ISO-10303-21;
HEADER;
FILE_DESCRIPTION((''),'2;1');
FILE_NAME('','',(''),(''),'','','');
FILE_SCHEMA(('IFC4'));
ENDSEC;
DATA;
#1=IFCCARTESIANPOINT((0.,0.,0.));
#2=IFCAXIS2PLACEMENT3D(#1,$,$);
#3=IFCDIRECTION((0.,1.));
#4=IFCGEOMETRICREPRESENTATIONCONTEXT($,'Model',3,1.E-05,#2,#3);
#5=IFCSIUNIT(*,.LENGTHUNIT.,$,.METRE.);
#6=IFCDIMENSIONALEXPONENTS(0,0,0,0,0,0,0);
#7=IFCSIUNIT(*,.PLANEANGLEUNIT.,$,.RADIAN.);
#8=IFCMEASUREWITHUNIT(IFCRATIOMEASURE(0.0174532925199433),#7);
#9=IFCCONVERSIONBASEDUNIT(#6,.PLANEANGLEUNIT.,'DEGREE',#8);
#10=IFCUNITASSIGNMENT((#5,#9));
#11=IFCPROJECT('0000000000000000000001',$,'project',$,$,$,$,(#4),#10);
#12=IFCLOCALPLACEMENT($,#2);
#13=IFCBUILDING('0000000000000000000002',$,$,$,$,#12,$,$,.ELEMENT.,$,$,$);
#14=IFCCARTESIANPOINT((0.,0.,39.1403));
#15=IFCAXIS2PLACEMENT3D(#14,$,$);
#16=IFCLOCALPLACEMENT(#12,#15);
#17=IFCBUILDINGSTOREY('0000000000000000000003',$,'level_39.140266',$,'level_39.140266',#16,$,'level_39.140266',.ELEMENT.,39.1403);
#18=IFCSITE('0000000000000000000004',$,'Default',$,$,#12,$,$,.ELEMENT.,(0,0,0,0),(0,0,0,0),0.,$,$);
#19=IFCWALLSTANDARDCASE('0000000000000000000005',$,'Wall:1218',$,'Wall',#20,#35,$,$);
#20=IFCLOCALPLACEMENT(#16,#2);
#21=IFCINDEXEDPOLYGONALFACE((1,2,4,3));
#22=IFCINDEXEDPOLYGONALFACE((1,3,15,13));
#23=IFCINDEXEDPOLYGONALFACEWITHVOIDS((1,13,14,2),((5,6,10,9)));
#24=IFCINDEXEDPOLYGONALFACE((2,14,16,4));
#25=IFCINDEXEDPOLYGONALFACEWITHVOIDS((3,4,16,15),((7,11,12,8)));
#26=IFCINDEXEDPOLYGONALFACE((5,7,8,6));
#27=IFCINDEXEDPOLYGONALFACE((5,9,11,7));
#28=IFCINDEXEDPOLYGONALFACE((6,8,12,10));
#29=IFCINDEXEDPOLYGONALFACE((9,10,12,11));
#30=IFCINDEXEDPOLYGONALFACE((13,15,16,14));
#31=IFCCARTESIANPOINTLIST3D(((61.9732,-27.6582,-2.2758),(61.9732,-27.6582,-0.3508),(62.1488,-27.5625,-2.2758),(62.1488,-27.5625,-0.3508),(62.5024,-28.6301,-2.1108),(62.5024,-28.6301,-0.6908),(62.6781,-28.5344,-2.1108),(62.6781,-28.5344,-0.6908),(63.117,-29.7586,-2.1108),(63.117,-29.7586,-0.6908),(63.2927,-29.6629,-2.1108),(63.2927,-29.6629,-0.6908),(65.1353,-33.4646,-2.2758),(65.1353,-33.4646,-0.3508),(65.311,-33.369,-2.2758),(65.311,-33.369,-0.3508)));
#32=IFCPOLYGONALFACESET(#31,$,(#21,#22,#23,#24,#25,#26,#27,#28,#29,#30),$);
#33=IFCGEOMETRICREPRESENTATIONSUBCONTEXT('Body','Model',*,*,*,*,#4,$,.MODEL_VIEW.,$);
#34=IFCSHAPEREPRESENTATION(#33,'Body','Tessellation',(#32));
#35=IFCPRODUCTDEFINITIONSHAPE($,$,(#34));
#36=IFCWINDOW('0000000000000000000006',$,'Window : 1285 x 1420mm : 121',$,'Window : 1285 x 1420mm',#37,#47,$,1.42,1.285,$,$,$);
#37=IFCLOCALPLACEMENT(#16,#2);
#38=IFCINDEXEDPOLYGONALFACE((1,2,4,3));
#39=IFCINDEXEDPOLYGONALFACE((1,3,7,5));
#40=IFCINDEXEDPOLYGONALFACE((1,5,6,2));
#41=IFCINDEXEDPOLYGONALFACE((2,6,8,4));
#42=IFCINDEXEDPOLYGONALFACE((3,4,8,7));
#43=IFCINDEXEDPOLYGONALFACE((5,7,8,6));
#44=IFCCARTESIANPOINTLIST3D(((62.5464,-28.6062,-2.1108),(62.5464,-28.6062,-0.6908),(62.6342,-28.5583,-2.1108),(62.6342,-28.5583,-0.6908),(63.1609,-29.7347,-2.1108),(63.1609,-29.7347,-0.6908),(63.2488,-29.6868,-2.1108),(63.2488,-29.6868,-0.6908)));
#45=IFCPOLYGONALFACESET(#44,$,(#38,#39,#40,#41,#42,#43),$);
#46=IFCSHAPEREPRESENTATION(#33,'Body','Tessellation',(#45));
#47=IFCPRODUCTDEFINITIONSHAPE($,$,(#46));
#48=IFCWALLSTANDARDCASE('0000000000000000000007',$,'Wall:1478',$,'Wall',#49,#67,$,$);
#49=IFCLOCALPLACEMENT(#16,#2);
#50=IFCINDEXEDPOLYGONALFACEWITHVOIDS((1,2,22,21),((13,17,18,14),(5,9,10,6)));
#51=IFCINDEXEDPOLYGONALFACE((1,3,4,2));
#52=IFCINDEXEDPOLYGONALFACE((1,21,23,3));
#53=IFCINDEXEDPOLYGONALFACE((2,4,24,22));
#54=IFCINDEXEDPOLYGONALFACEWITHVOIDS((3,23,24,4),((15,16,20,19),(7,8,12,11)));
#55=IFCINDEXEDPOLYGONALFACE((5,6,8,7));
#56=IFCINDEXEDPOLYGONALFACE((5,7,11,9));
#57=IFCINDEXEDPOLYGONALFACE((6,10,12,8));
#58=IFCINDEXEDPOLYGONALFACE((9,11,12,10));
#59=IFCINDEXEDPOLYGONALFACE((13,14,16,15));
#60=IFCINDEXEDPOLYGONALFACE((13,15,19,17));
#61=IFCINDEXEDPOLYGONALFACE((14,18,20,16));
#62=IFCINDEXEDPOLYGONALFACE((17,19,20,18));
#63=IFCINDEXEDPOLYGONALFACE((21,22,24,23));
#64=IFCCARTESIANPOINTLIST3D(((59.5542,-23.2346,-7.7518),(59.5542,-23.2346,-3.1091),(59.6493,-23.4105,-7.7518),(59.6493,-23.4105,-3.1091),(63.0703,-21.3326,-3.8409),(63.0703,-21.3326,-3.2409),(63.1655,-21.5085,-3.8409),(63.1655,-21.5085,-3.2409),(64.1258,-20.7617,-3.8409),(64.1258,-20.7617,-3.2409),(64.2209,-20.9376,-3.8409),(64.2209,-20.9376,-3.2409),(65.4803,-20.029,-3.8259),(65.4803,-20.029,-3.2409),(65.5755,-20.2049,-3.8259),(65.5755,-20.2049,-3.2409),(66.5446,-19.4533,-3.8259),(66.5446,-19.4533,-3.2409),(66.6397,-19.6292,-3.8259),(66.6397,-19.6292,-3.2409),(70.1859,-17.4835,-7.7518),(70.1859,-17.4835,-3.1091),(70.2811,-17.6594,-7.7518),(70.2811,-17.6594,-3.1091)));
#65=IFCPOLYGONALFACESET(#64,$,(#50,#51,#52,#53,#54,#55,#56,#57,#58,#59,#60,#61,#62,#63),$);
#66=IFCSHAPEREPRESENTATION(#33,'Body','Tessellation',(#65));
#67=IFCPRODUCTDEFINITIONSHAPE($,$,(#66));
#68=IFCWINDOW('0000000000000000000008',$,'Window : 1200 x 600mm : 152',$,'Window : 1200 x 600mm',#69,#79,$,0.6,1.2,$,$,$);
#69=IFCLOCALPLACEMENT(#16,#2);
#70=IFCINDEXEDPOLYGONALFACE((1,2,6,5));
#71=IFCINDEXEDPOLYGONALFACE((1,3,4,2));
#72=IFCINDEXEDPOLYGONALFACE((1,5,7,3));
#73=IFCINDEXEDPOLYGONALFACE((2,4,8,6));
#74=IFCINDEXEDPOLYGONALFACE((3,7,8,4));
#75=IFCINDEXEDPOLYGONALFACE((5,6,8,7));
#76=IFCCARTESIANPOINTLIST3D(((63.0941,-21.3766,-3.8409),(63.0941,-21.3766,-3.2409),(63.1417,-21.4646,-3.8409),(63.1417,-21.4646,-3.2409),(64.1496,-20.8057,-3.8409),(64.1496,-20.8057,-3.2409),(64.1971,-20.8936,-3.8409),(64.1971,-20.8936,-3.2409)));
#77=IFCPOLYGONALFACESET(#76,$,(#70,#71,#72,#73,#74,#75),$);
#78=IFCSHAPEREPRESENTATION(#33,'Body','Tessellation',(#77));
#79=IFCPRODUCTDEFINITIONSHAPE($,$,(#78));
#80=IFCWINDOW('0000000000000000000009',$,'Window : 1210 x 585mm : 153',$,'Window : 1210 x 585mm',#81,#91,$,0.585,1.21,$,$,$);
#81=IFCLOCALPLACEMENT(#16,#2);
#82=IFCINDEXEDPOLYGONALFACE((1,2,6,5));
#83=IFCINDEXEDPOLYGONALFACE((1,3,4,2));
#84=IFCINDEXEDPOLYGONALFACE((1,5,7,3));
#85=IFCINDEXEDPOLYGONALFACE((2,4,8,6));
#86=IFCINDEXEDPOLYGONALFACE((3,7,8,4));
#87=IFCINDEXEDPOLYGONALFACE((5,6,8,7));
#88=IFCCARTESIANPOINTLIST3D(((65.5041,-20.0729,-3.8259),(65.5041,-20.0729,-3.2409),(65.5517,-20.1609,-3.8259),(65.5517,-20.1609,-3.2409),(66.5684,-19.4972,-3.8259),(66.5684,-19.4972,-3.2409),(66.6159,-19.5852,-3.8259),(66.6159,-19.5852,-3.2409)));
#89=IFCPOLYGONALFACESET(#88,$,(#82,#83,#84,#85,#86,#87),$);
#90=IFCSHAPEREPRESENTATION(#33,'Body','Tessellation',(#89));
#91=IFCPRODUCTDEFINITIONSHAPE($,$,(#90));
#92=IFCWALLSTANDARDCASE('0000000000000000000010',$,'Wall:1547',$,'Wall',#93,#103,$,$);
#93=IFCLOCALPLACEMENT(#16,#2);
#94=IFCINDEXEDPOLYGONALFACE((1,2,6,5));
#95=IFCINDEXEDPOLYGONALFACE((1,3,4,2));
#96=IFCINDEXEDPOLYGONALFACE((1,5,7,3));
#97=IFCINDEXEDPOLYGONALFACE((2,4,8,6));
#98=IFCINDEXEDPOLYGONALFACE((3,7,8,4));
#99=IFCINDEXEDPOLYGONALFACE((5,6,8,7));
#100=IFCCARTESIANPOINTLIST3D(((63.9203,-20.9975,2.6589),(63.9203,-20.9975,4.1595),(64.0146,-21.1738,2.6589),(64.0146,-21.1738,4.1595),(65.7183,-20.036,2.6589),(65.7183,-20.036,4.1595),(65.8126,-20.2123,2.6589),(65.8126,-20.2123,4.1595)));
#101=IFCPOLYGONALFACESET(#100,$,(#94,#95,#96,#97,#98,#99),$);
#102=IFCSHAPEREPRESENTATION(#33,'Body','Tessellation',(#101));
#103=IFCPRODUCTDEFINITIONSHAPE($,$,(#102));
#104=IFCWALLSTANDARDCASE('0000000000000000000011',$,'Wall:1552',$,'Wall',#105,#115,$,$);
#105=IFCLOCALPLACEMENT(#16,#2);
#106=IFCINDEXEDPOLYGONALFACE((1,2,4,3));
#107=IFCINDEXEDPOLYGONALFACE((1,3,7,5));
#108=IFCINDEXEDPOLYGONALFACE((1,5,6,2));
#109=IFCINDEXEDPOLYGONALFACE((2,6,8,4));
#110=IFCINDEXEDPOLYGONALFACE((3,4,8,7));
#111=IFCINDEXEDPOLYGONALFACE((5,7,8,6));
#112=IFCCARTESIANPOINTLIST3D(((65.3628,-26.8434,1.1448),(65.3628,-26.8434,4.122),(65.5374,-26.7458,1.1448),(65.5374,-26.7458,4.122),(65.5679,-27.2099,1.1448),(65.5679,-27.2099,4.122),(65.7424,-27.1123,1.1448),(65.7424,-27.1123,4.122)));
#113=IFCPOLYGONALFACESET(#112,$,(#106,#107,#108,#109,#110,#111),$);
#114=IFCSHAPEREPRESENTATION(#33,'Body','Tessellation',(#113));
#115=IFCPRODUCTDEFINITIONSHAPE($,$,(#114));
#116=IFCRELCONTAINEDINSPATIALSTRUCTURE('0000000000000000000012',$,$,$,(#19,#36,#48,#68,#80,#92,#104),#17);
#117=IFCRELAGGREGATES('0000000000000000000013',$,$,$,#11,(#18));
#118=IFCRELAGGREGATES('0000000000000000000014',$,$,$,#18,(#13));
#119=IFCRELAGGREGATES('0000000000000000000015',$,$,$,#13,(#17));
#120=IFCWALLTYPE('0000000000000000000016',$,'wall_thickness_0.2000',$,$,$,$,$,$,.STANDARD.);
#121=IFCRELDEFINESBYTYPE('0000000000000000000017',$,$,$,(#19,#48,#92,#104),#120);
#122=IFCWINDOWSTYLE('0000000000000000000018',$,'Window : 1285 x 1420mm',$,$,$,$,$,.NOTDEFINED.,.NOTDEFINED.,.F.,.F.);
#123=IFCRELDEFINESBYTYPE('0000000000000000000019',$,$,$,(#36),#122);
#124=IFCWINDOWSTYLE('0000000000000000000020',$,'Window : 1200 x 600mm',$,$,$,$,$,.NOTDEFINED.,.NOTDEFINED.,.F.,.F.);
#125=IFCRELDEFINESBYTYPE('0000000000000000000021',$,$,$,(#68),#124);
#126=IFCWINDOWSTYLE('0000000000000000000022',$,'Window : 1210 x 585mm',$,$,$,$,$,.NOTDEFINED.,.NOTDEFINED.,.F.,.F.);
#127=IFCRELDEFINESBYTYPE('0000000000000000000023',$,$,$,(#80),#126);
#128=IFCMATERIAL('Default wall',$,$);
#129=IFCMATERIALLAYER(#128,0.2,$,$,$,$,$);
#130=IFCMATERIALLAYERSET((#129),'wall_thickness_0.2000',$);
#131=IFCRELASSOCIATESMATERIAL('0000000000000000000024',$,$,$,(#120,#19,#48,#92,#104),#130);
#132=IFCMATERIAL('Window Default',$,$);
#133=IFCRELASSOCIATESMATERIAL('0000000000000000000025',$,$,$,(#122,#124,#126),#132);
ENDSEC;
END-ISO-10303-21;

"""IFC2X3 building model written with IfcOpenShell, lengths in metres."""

from ifc_helpers import new_model, entity, si_unit, converted_unit, direction, frame, frame_2d, origin, origin_2d_with_axis, place, context, subcontext, project, spatial, polyline, rectangle, outline, extrude, source, transform, mapped, material, layer, layer_set, layer_usage, type_object, type_shapes, element, fill, save


model = new_model("IFC2X3")

# Units and contexts
model_context = context("Model", 3, precision=1e-05, world=origin(), true_north=direction((0.0, 1.0)))
body_context = subcontext(model_context, "Body", "Model", "MODEL_VIEW")
ifc_project = project(units=[si_unit("LENGTHUNIT", "METRE"), converted_unit("PLANEANGLEUNIT", "DEGREE", entity("IfcRatioMeasure", 0.0174532925199433), si_unit("PLANEANGLEUNIT", "RADIAN"), dimensions=[0, 0, 0, 0, 0, 0, 0])], contexts=[model_context])

# Site, building, storey
placement_1 = place(None, origin())
site = spatial("IfcSite", under=ifc_project, at=placement_1, Name="Default", CompositionType="ELEMENT", RefLatitude=(0, 0, 0, 0), RefLongitude=(0, 0, 0, 0), RefElevation=0.0)
building = spatial("IfcBuilding", under=site, at=placement_1, CompositionType="ELEMENT")
storey_placement = place(placement_1, frame((0.0, 0.0, 39.1403)))
storey = spatial("IfcBuildingStorey", under=building, at=storey_placement, Name="level_39.140266", ObjectType="level_39.140266", LongName="level_39.140266", CompositionType="ELEMENT", Elevation=39.1403)

# Shared definitions
ifc_material_1 = material(Name="Default wall")
ifc_layer = layer(ifc_material_1, 0.2)
ifc_layer_set = layer_set([ifc_layer], Name="wall_thickness_0.2000")
ifc_layer_usage = layer_usage(ifc_layer_set, "AXIS2", "POSITIVE", -0.1)
wall_type = type_object("IfcWallType", Name="wall_thickness_0.2000", PredefinedType="STANDARD", material=ifc_layer_set)

# Shared definitions
ifc_material_2 = material(Name="Window Default")

# Wall, opening, window
placement_2 = place(placement_1, frame((0.0, 0.0, 36.8645)))
wall_1_placement = place(placement_2, frame((62.061, -27.6104, 0.0), z_axis=(0.0, 0.0, 1.0), x_axis=(0.478271, -0.878213, 0.0)))
wall_1 = element("IfcWallStandardCase", 1, at=wall_1_placement, inside=storey, type_object=wall_type, material=ifc_layer_usage, Name="Wall:1218", ObjectType="Wall", context=body_context, shape_type="SweptSolid", body=[
    extrude(outline(polyline([(6.6117, -0.1), (6.6117, 0.1), (0.0, 0.1), (0.0, -0.1), (6.6117, -0.1)])), origin(), (0.0, 0.0, 1.0), 1.925),
])
opening_1_placement = place(wall_1_placement, frame((1.1067, -0.1, 0.165)))
opening_1 = element("IfcOpeningElement", 2, at=opening_1_placement, cuts=wall_1, ObjectType="Opening", context=body_context, shape_type="SweptSolid", body=[
    extrude(rectangle(XDim=1.285, YDim=1.42, at=frame_2d((0.71, 0.6425), x_axis=(0.0, 1.0))), frame((0.0, 0.0, 0.0), z_axis=(0.0, 1.0, 0.0), x_axis=(0.0, 0.0, 1.0)), (0.0, 0.0, 1.0), 0.2),
])
window_style_1 = type_object("IfcWindowStyle", Name="Window : 1285 x 1420mm", ConstructionType="NOTDEFINED", OperationType="NOTDEFINED", ParameterTakesPrecedence=False, Sizeable=False, material=ifc_material_2)
shared_shape_1 = source(origin(), body_context, "Body", "SweptSolid", [
    extrude(rectangle(XDim=0.1, YDim=1.285, at=origin_2d_with_axis()), frame((0.6425, 0.1, 0.0), z_axis=(0.0, 0.0, 1.0), x_axis=(0.0, 1.0, 0.0)), (0.0, 0.0, 1.0), 1.42),
])
type_shapes(window_style_1, [shared_shape_1])
window_1_placement = place(opening_1_placement, origin())
window_1 = element("IfcWindow", 3, at=window_1_placement, inside=storey, type_object=window_style_1, Name="Window : 1285 x 1420mm : 121", ObjectType="Window : 1285 x 1420mm", OverallHeight=1.42, OverallWidth=1.285, context=body_context, shape_type="MappedRepresentation", body=[
    mapped(shared_shape_1, transform((0.0, 0.0, 0.0), scale=1.0)),
])
fill(opening_1, window_1)

# Wall, openings, windows
placement_3 = place(placement_1, frame((0.0, 0.0, 31.3885)))
wall_2_placement = place(placement_3, frame((59.6018, -23.3226, 0.0), z_axis=(0.0, 0.0, 1.0), x_axis=(0.87956, 0.475788, 0.0)))
wall_2 = element("IfcWallStandardCase", 4, at=wall_2_placement, inside=storey, type_object=wall_type, material=ifc_layer_usage, Name="Wall:1478", ObjectType="Wall", context=body_context, shape_type="SweptSolid", body=[
    extrude(outline(polyline([(12.0876, -0.1), (12.0876, 0.1), (0.0, 0.1), (0.0, -0.1), (12.0876, -0.1)])), origin(), (0.0, 0.0, 1.0), 4.6426),
])
opening_2_placement = place(wall_2_placement, frame((3.9976, -0.1, 3.9109)))
opening_2 = element("IfcOpeningElement", 5, at=opening_2_placement, cuts=wall_2, ObjectType="Opening", context=body_context, shape_type="SweptSolid", body=[
    extrude(rectangle(XDim=1.2, YDim=0.6, at=frame_2d((0.3, 0.6), x_axis=(0.0, 1.0))), frame((0.0, 0.0, 0.0), z_axis=(0.0, 1.0, 0.0), x_axis=(0.0, 0.0, 1.0)), (0.0, 0.0, 1.0), 0.2),
])
opening_3_placement = place(wall_2_placement, frame((6.7376, -0.1, 3.9259)))
opening_3 = element("IfcOpeningElement", 6, at=opening_3_placement, cuts=wall_2, ObjectType="Opening", context=body_context, shape_type="SweptSolid", body=[
    extrude(rectangle(XDim=1.21, YDim=0.585, at=frame_2d((0.2925, 0.605), x_axis=(0.0, 1.0))), frame((0.0, 0.0, 0.0), z_axis=(0.0, 1.0, 0.0), x_axis=(0.0, 0.0, 1.0)), (0.0, 0.0, 1.0), 0.2),
])
window_style_2 = type_object("IfcWindowStyle", Name="Window : 1200 x 600mm", ConstructionType="NOTDEFINED", OperationType="NOTDEFINED", ParameterTakesPrecedence=False, Sizeable=False, material=ifc_material_2)
shared_shape_2 = source(origin(), body_context, "Body", "SweptSolid", [
    extrude(rectangle(XDim=0.1, YDim=1.2, at=origin_2d_with_axis()), frame((0.6, 0.1, 0.0), z_axis=(0.0, 0.0, 1.0), x_axis=(0.0, 1.0, 0.0)), (0.0, 0.0, 1.0), 0.6),
])
type_shapes(window_style_2, [shared_shape_2])
window_2_placement = place(opening_2_placement, origin())
window_2 = element("IfcWindow", 7, at=window_2_placement, inside=storey, type_object=window_style_2, Name="Window : 1200 x 600mm : 152", ObjectType="Window : 1200 x 600mm", OverallHeight=0.6, OverallWidth=1.2, context=body_context, shape_type="MappedRepresentation", body=[
    mapped(shared_shape_2, transform((0.0, 0.0, 0.0), scale=1.0)),
])
fill(opening_2, window_2)
window_style_3 = type_object("IfcWindowStyle", Name="Window : 1210 x 585mm", ConstructionType="NOTDEFINED", OperationType="NOTDEFINED", ParameterTakesPrecedence=False, Sizeable=False, material=ifc_material_2)
shared_shape_3 = source(origin(), body_context, "Body", "SweptSolid", [
    extrude(rectangle(XDim=0.1, YDim=1.21, at=origin_2d_with_axis()), frame((0.605, 0.1, 0.0), z_axis=(0.0, 0.0, 1.0), x_axis=(0.0, 1.0, 0.0)), (0.0, 0.0, 1.0), 0.585),
])
type_shapes(window_style_3, [shared_shape_3])
window_3_placement = place(opening_3_placement, origin())
window_3 = element("IfcWindow", 8, at=window_3_placement, inside=storey, type_object=window_style_3, Name="Window : 1210 x 585mm : 153", ObjectType="Window : 1210 x 585mm", OverallHeight=0.585, OverallWidth=1.21, context=body_context, shape_type="MappedRepresentation", body=[
    mapped(shared_shape_3, transform((0.0, 0.0, 0.0), scale=1.0)),
])
fill(opening_3, window_3)

# Walls
placement_4 = place(placement_1, frame((0.0, 0.0, 41.7992)))
wall_3_placement = place(placement_4, frame((63.9675, -21.0856, 0.0), z_axis=(0.0, 0.0, 1.0), x_axis=(0.881832, 0.471565, 0.0)))
element("IfcWallStandardCase", 9, at=wall_3_placement, inside=storey, type_object=wall_type, material=ifc_layer_usage, Name="Wall:1547", ObjectType="Wall", context=body_context, shape_type="SweptSolid", body=[
    extrude(outline(polyline([(2.0389, -0.1), (2.0389, 0.1), (0.0, 0.1), (0.0, -0.1), (2.0389, -0.1)])), origin(), (0.0, 0.0, 1.0), 1.5006),
])
placement_5 = place(placement_1, frame((0.0, 0.0, 40.2851)))
wall_4_placement = place(placement_5, frame((65.4501, -26.7946, 0.0), z_axis=(0.0, 0.0, 1.0), x_axis=(0.488206, -0.872728, 0.0)))
element("IfcWallStandardCase", 10, at=wall_4_placement, inside=storey, type_object=wall_type, material=ifc_layer_usage, Name="Wall:1552", ObjectType="Wall", context=body_context, shape_type="SweptSolid", body=[
    extrude(outline(polyline([(0.42, -0.1), (0.42, 0.1), (0.0, 0.1), (0.0, -0.1), (0.42, -0.1)])), origin(), (0.0, 0.0, 1.0), 2.9773),
])

save(model, "model.ifc")
